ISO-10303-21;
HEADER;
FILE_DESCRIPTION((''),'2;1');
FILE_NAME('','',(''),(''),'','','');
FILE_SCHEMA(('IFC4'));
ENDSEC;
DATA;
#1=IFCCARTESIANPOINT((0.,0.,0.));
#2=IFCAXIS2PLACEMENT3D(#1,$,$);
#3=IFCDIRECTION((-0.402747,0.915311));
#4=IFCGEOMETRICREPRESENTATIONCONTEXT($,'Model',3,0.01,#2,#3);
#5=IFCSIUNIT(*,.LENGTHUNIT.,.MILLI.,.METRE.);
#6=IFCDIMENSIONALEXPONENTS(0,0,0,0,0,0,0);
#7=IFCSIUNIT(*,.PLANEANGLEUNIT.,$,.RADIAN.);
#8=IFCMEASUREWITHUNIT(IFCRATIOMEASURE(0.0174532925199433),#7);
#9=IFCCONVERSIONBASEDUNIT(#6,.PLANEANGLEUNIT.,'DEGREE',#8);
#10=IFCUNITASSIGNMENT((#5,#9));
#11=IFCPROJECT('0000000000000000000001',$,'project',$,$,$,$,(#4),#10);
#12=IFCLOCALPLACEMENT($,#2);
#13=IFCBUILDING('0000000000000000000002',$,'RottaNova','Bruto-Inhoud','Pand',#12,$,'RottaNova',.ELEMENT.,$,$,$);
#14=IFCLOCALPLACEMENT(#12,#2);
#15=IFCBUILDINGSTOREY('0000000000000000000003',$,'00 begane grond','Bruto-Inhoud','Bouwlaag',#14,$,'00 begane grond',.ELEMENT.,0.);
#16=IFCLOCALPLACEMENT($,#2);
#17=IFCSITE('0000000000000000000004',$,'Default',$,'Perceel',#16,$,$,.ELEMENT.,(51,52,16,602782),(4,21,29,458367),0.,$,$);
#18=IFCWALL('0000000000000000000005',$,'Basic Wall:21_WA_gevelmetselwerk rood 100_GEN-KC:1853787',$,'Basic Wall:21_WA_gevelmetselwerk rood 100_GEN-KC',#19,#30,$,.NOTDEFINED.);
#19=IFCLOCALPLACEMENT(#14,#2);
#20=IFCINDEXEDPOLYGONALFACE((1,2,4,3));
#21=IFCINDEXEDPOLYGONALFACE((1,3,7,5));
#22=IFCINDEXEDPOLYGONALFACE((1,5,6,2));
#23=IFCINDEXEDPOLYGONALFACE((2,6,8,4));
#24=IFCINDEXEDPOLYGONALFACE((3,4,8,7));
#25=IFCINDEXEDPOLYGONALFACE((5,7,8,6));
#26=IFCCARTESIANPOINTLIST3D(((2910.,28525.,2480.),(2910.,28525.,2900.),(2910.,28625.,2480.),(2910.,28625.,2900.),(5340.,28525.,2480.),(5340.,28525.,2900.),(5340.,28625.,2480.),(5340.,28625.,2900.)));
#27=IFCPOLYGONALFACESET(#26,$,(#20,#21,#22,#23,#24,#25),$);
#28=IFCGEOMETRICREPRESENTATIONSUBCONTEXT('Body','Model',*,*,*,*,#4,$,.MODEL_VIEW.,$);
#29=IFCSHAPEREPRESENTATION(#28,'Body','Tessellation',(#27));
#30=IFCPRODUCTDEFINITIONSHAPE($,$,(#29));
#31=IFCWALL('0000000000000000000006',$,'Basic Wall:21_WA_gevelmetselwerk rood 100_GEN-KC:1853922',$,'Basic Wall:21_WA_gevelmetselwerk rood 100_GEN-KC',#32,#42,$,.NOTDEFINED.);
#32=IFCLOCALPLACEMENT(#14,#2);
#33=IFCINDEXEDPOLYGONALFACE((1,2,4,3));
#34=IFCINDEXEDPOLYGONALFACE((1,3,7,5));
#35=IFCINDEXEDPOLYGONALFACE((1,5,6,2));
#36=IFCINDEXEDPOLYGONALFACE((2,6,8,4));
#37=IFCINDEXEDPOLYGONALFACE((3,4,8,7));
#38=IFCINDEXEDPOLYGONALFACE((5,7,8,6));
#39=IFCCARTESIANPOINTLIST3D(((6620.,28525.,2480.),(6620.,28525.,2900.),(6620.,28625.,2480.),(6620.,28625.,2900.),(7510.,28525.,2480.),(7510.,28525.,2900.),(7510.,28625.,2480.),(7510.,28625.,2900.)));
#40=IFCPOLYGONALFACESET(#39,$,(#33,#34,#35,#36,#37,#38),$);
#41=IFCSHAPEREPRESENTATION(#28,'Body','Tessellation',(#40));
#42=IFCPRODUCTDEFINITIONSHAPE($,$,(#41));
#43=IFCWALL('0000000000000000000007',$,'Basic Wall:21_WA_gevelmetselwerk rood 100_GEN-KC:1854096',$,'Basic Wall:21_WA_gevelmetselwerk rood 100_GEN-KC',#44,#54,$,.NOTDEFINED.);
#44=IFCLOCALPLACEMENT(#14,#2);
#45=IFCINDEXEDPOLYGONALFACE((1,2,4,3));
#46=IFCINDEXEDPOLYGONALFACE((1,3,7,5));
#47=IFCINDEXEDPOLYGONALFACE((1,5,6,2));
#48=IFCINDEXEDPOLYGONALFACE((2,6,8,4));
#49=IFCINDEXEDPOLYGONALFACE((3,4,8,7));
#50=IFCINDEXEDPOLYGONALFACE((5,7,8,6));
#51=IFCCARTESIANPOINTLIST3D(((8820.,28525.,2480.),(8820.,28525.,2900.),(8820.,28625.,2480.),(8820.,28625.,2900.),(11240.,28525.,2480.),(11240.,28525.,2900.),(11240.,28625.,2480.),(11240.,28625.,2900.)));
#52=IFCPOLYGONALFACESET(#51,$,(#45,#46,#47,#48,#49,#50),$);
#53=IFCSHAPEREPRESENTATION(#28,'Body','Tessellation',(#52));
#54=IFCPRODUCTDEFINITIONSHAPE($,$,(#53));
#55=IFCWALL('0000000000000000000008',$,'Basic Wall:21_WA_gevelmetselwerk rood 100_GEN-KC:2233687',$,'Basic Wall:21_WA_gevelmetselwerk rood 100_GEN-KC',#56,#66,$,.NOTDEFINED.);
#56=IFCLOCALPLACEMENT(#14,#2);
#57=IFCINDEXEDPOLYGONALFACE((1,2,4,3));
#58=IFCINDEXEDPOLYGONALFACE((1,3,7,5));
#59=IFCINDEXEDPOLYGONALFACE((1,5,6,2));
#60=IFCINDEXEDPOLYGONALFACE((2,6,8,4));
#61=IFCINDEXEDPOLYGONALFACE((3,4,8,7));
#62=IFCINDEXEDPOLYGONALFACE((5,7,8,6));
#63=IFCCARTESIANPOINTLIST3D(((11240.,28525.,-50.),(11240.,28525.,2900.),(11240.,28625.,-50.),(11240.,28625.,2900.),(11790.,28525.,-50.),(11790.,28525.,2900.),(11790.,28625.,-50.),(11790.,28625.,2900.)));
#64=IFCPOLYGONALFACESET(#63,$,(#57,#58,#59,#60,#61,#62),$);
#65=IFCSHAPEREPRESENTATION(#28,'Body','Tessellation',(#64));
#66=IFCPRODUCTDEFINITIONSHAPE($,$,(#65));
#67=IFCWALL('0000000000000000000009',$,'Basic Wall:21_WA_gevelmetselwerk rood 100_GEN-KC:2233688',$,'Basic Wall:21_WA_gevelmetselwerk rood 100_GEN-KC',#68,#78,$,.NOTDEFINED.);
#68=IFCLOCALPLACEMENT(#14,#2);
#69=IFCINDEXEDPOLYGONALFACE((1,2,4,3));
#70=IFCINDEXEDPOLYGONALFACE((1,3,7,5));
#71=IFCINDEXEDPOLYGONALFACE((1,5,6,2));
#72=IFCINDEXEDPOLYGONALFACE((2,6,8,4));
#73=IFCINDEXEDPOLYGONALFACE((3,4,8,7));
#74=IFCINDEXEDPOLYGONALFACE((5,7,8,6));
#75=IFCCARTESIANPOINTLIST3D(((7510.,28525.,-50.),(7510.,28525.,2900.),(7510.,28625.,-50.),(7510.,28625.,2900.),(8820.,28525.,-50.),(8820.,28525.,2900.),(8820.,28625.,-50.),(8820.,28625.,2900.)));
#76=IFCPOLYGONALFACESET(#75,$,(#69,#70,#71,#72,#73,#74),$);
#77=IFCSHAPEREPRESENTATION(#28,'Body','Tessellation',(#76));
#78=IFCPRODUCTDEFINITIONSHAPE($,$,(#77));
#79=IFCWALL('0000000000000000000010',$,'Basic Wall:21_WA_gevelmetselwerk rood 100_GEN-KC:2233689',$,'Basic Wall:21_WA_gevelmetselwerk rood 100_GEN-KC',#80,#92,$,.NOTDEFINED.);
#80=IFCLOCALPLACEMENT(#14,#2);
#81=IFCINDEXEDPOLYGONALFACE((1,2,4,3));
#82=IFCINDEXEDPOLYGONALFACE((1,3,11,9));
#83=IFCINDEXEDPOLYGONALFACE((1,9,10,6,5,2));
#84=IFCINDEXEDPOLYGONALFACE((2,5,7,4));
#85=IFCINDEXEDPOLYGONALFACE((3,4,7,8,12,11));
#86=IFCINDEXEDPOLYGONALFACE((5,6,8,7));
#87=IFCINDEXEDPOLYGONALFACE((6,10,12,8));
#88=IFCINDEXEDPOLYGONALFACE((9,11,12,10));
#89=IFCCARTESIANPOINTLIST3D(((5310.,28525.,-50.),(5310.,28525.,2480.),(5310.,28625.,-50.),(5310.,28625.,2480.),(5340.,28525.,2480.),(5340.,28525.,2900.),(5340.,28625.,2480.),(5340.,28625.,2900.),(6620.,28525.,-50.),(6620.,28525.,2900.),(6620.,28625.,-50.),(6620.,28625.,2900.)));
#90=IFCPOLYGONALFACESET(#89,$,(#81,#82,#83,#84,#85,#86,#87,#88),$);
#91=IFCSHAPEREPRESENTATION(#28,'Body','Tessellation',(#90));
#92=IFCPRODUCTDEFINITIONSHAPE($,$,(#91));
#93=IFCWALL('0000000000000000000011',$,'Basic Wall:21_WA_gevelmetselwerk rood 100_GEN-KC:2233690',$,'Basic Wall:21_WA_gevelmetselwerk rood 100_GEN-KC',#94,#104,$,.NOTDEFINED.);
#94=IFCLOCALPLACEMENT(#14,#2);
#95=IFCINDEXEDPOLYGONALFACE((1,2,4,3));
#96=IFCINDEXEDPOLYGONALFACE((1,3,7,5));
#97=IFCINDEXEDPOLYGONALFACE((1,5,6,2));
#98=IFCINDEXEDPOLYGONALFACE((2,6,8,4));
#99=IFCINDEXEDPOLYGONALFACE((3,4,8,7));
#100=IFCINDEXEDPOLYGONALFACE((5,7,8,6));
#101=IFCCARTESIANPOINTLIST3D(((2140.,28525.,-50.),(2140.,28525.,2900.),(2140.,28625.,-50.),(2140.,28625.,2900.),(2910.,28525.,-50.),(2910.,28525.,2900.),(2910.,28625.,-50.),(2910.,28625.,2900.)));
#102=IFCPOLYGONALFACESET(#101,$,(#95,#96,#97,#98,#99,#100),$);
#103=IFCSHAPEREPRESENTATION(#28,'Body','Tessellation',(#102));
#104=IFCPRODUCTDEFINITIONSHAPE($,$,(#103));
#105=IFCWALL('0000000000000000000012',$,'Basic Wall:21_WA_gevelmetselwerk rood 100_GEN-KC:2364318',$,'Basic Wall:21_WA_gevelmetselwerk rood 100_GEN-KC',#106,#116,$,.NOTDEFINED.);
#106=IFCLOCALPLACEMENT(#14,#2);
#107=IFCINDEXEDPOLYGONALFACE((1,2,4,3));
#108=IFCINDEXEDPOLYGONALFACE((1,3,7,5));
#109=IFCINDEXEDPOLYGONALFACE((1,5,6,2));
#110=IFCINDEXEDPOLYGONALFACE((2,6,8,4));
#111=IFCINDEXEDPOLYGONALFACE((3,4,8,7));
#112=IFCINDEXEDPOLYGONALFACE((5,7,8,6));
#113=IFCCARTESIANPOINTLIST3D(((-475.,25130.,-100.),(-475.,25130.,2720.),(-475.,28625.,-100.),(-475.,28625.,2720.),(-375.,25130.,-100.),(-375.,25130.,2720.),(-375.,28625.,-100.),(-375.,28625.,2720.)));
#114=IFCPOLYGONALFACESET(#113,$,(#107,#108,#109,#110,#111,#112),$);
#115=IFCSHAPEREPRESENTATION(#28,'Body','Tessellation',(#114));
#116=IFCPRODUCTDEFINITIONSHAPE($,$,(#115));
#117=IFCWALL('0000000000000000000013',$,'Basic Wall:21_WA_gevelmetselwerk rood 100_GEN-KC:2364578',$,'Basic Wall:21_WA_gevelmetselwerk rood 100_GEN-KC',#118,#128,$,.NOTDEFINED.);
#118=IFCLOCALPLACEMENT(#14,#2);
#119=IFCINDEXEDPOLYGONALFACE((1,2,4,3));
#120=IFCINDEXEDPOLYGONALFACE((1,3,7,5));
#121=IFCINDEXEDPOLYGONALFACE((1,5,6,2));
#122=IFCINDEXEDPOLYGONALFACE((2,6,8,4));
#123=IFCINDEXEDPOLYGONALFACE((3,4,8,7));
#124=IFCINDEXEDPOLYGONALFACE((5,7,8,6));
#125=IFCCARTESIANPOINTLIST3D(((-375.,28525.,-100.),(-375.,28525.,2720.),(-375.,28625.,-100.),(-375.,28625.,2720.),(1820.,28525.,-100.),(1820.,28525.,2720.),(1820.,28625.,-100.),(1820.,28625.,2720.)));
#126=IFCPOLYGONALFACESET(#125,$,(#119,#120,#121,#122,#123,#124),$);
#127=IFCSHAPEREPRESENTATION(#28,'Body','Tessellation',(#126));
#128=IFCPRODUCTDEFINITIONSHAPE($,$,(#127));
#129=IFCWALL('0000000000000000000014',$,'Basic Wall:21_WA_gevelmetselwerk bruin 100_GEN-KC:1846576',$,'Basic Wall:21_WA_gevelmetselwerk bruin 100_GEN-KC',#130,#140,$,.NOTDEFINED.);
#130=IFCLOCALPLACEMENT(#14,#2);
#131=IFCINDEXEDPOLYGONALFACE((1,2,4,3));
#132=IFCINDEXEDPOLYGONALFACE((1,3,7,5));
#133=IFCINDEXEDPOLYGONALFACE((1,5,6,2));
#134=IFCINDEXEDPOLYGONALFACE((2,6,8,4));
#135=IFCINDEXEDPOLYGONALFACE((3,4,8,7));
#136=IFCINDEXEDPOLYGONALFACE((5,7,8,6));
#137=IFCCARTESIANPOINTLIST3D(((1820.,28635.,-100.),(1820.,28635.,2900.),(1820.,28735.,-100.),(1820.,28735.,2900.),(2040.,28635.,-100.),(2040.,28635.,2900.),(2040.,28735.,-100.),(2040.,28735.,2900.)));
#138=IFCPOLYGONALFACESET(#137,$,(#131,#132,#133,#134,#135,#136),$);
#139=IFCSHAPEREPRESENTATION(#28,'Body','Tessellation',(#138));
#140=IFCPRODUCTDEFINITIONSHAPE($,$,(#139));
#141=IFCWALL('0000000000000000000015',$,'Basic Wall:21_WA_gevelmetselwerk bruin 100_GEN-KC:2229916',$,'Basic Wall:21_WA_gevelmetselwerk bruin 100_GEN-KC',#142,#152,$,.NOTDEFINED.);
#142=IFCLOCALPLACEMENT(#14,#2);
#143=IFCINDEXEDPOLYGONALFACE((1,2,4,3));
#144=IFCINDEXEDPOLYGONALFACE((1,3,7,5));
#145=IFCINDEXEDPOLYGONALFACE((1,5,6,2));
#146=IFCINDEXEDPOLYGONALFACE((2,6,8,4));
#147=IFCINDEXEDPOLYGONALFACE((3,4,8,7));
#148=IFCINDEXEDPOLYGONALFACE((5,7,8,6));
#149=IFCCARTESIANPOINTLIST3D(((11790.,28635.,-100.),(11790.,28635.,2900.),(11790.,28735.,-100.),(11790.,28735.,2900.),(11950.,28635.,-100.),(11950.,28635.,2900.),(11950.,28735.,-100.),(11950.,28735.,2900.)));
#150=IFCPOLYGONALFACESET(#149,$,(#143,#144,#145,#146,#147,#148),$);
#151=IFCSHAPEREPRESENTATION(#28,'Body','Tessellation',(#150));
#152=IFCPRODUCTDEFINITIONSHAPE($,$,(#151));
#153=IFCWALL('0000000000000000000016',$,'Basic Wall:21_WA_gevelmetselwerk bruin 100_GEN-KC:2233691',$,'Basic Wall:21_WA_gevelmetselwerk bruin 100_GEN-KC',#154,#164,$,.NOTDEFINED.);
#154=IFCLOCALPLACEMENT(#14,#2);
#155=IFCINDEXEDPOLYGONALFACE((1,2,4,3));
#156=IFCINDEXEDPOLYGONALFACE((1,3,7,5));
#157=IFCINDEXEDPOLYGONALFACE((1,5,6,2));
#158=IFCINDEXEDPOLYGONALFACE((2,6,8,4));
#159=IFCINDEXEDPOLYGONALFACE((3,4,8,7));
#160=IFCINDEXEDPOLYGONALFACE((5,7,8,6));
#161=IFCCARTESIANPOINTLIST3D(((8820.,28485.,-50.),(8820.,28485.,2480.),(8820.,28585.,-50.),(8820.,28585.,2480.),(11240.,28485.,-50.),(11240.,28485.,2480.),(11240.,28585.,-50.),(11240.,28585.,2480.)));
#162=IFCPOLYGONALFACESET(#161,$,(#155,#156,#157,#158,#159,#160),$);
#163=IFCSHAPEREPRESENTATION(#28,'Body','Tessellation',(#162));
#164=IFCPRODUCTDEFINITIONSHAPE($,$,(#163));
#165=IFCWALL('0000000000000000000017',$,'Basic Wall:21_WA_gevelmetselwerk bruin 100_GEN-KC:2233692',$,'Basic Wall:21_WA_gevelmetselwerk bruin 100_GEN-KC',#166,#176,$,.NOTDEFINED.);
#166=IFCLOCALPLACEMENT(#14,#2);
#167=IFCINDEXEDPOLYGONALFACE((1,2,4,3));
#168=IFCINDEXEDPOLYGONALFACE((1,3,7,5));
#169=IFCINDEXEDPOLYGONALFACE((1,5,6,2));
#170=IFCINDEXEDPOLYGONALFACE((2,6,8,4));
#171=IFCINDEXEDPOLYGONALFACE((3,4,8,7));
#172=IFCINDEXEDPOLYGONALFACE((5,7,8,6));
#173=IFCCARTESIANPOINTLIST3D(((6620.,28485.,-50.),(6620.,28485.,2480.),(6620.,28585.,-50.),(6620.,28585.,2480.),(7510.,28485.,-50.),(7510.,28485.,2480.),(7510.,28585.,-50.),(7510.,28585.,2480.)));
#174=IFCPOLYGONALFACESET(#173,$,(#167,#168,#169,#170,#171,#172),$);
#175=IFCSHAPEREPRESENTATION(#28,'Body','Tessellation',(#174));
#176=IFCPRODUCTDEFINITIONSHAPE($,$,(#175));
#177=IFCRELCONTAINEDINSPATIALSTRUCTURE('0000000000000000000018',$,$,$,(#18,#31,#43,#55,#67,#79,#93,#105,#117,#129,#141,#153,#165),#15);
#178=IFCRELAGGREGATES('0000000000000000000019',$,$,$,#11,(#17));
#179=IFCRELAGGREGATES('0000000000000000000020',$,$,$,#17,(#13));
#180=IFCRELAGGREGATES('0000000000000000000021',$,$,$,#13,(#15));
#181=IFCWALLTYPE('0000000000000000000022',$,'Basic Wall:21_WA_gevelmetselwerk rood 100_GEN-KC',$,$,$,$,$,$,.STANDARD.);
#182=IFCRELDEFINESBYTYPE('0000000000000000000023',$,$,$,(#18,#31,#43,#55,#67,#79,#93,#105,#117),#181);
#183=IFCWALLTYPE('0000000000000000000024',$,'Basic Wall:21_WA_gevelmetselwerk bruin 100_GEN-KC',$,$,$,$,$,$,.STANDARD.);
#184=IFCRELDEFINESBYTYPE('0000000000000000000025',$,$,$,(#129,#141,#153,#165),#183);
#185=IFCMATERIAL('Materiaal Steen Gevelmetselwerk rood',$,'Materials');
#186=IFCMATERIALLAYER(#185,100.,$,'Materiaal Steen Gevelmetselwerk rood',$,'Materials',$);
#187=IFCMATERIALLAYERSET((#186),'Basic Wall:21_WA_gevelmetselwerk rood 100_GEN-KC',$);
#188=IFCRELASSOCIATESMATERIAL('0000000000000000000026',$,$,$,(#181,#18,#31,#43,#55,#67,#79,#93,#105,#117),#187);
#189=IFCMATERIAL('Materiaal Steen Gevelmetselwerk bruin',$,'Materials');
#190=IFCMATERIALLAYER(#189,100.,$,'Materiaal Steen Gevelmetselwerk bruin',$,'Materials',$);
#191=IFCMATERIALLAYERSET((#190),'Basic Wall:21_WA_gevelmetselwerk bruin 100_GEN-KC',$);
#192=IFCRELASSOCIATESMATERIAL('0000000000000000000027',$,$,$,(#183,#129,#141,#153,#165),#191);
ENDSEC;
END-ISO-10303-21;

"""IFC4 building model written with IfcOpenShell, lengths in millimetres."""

from ifc_helpers import new_model, entity, si_unit, converted_unit, direction, frame, frame_2d, origin, place, context, subcontext, project, spatial, polyline, rectangle, extrude, clip, bounded_halfspace, material, layer, layer_set, type_object, element, save


model = new_model("IFC4")

# Units and contexts
model_context = context("Model", 3, precision=0.01, world=origin(), true_north=direction((-0.402747, 0.915311)))
body_context = subcontext(model_context, "Body", "Model", "MODEL_VIEW")
ifc_project = project(units=[si_unit("LENGTHUNIT", "METRE", prefix="MILLI"), converted_unit("PLANEANGLEUNIT", "DEGREE", entity("IfcRatioMeasure", 0.0174532925199433), si_unit("PLANEANGLEUNIT", "RADIAN"), dimensions=[0, 0, 0, 0, 0, 0, 0])], contexts=[model_context])

# Site, building, storey
site_placement = place(None, origin())
site = spatial("IfcSite", under=ifc_project, at=site_placement, Name="Default", ObjectType="Perceel", CompositionType="ELEMENT", RefLatitude=(51, 52, 16, 602782), RefLongitude=(4, 21, 29, 458367), RefElevation=0.0)
building_placement = place(None, origin())
building = spatial("IfcBuilding", under=site, at=building_placement, Name="RottaNova", Description="Bruto-Inhoud", ObjectType="Pand", LongName="RottaNova", CompositionType="ELEMENT")
storey_placement = place(building_placement, origin())
storey = spatial("IfcBuildingStorey", under=building, at=storey_placement, Name="00 begane grond", Description="Bruto-Inhoud", ObjectType="Bouwlaag", LongName="00 begane grond", CompositionType="ELEMENT", Elevation=0.0)

# Walls
ifc_material_1 = material(Name="Materiaal Steen Gevelmetselwerk rood", Category="Materials")
ifc_layer_1 = layer(ifc_material_1, 100.0, Name="Materiaal Steen Gevelmetselwerk rood", Category="Materials")
ifc_layer_set_1 = layer_set([ifc_layer_1], Name="Basic Wall:21_WA_gevelmetselwerk rood 100_GEN-KC")
wall_type_1 = type_object("IfcWallType", Name="Basic Wall:21_WA_gevelmetselwerk rood 100_GEN-KC", PredefinedType="STANDARD", material=ifc_layer_set_1)
wall_1_placement = place(storey_placement, frame((2910.0, 28575.0, 2480.0)))
element("IfcWall", 1, at=wall_1_placement, inside=storey, type_object=wall_type_1, material=ifc_layer_set_1, Name="Basic Wall:21_WA_gevelmetselwerk rood 100_GEN-KC:1853787", ObjectType="Basic Wall:21_WA_gevelmetselwerk rood 100_GEN-KC", PredefinedType="NOTDEFINED", context=body_context, shape_type="SweptSolid", body=[
    extrude(rectangle(XDim=2430.0, YDim=100.0, at=frame_2d((1215.0, 0.0), x_axis=(-1.0, 0.0))), origin(), (0.0, 0.0, 1.0), 420.0),
])
wall_2_placement = place(storey_placement, frame((6620.0, 28575.0, 2480.0)))
element("IfcWall", 2, at=wall_2_placement, inside=storey, type_object=wall_type_1, material=ifc_layer_set_1, Name="Basic Wall:21_WA_gevelmetselwerk rood 100_GEN-KC:1853922", ObjectType="Basic Wall:21_WA_gevelmetselwerk rood 100_GEN-KC", PredefinedType="NOTDEFINED", context=body_context, shape_type="Clipping", body=[
    clip(extrude(rectangle(XDim=890.0, YDim=100.0, at=frame_2d((445.0, 0.0), x_axis=(-1.0, 0.0))), origin(), (0.0, 0.0, 1.0), 420.0), bounded_halfspace(frame((890.0, -50.0, 420.0), z_axis=(-1.0, 0.0, 0.0), x_axis=(0.0, 1.0, 0.0)), True, frame((890.0, -50.0, 420.0), z_axis=(-1.0, 0.0, 0.0), x_axis=(0.0, 1.0, 0.0)), polyline([(0.0, 0.0), (30480.0, 0.0), (30480.0, 128016.0), (0.0, 128016.0), (0.0, 0.0)]))),
])
wall_3_placement = place(storey_placement, frame((8820.0, 28575.0, 2480.0)))
element("IfcWall", 3, at=wall_3_placement, inside=storey, type_object=wall_type_1, material=ifc_layer_set_1, Name="Basic Wall:21_WA_gevelmetselwerk rood 100_GEN-KC:1854096", ObjectType="Basic Wall:21_WA_gevelmetselwerk rood 100_GEN-KC", PredefinedType="NOTDEFINED", context=body_context, shape_type="SweptSolid", body=[
    extrude(rectangle(XDim=2420.0, YDim=100.0, at=frame_2d((1210.0, 0.0), x_axis=(-1.0, 0.0))), origin(), (0.0, 0.0, 1.0), 420.0),
])
wall_4_placement = place(storey_placement, frame((11240.0, 28575.0, -50.0)))
element("IfcWall", 4, at=wall_4_placement, inside=storey, type_object=wall_type_1, material=ifc_layer_set_1, Name="Basic Wall:21_WA_gevelmetselwerk rood 100_GEN-KC:2233687", ObjectType="Basic Wall:21_WA_gevelmetselwerk rood 100_GEN-KC", PredefinedType="NOTDEFINED", context=body_context, shape_type="SweptSolid", body=[
    extrude(rectangle(XDim=550.0, YDim=100.0, at=frame_2d((275.0, 0.0), x_axis=(-1.0, 0.0))), origin(), (0.0, 0.0, 1.0), 2950.0),
])
wall_5_placement = place(storey_placement, frame((7510.0, 28575.0, -50.0)))
element("IfcWall", 5, at=wall_5_placement, inside=storey, type_object=wall_type_1, material=ifc_layer_set_1, Name="Basic Wall:21_WA_gevelmetselwerk rood 100_GEN-KC:2233688", ObjectType="Basic Wall:21_WA_gevelmetselwerk rood 100_GEN-KC", PredefinedType="NOTDEFINED", context=body_context, shape_type="SweptSolid", body=[
    extrude(rectangle(XDim=1310.0, YDim=100.0, at=frame_2d((655.0, 0.0), x_axis=(-1.0, 0.0))), origin(), (0.0, 0.0, 1.0), 2950.0),
])
wall_6_placement = place(storey_placement, frame((5310.0, 28575.0, -50.0)))
element("IfcWall", 6, at=wall_6_placement, inside=storey, type_object=wall_type_1, material=ifc_layer_set_1, Name="Basic Wall:21_WA_gevelmetselwerk rood 100_GEN-KC:2233689", ObjectType="Basic Wall:21_WA_gevelmetselwerk rood 100_GEN-KC", PredefinedType="NOTDEFINED", context=body_context, shape_type="Clipping", body=[
    clip(clip(extrude(rectangle(XDim=1310.0, YDim=100.0, at=frame_2d((655.0, 0.0), x_axis=(-1.0, 0.0))), origin(), (0.0, 0.0, 1.0), 2950.0), bounded_halfspace(frame((30.0, -50.0, 2530.0), z_axis=(0.0, 0.0, -1.0), x_axis=(0.0, 1.0, 0.0)), True, frame((30.0, -50.0, 2530.0), z_axis=(0.0, 0.0, -1.0), x_axis=(0.0, 1.0, 0.0)), polyline([(0.0, 0.0), (0.0, -30.0), (100.0, -30.0), (100.0, 0.0), (0.0, 0.0)]))), bounded_halfspace(frame((30.0, 50.0, 2530.0), z_axis=(1.0, 0.0, 0.0), x_axis=(0.0, 1.0, 0.0)), True, frame((30.0, 50.0, 2530.0), z_axis=(1.0, 0.0, 0.0), x_axis=(0.0, 1.0, 0.0)), polyline([(0.0, 0.0), (0.0, 128016.0), (-30480.0, 128016.0), (-30480.0, 0.0), (0.0, 0.0)]))),
])
wall_7_placement = place(storey_placement, frame((2140.0, 28575.0, -50.0)))
element("IfcWall", 7, at=wall_7_placement, inside=storey, type_object=wall_type_1, material=ifc_layer_set_1, Name="Basic Wall:21_WA_gevelmetselwerk rood 100_GEN-KC:2233690", ObjectType="Basic Wall:21_WA_gevelmetselwerk rood 100_GEN-KC", PredefinedType="NOTDEFINED", context=body_context, shape_type="SweptSolid", body=[
    extrude(rectangle(XDim=770.0, YDim=100.0, at=frame_2d((385.0, 0.0), x_axis=(-1.0, 0.0))), origin(), (0.0, 0.0, 1.0), 2950.0),
])
wall_8_placement = place(storey_placement, frame((-425.0, 25130.0, -100.0), z_axis=(0.0, 0.0, 1.0), x_axis=(0.0, 1.0, 0.0)))
element("IfcWall", 8, at=wall_8_placement, inside=storey, type_object=wall_type_1, material=ifc_layer_set_1, Name="Basic Wall:21_WA_gevelmetselwerk rood 100_GEN-KC:2364318", ObjectType="Basic Wall:21_WA_gevelmetselwerk rood 100_GEN-KC", PredefinedType="NOTDEFINED", context=body_context, shape_type="SweptSolid", body=[
    extrude(rectangle(XDim=3495.0, YDim=100.0, at=frame_2d((1747.5, 0.0), x_axis=(-1.0, 0.0))), origin(), (0.0, 0.0, 1.0), 2820.0),
])
wall_9_placement = place(storey_placement, frame((1820.0, 28575.0, -100.0), z_axis=(0.0, 0.0, 1.0), x_axis=(-1.0, 0.0, 0.0)))
element("IfcWall", 9, at=wall_9_placement, inside=storey, type_object=wall_type_1, material=ifc_layer_set_1, Name="Basic Wall:21_WA_gevelmetselwerk rood 100_GEN-KC:2364578", ObjectType="Basic Wall:21_WA_gevelmetselwerk rood 100_GEN-KC", PredefinedType="NOTDEFINED", context=body_context, shape_type="SweptSolid", body=[
    extrude(rectangle(XDim=2195.0, YDim=100.0, at=frame_2d((1097.5, 0.0), x_axis=(-1.0, 0.0))), origin(), (0.0, 0.0, 1.0), 2820.0),
])
ifc_material_2 = material(Name="Materiaal Steen Gevelmetselwerk bruin", Category="Materials")
ifc_layer_2 = layer(ifc_material_2, 100.0, Name="Materiaal Steen Gevelmetselwerk bruin", Category="Materials")
ifc_layer_set_2 = layer_set([ifc_layer_2], Name="Basic Wall:21_WA_gevelmetselwerk bruin 100_GEN-KC")
wall_type_2 = type_object("IfcWallType", Name="Basic Wall:21_WA_gevelmetselwerk bruin 100_GEN-KC", PredefinedType="STANDARD", material=ifc_layer_set_2)
wall_10_placement = place(storey_placement, frame((1820.0, 28685.0, -100.0)))
element("IfcWall", 10, at=wall_10_placement, inside=storey, type_object=wall_type_2, material=ifc_layer_set_2, Name="Basic Wall:21_WA_gevelmetselwerk bruin 100_GEN-KC:1846576", ObjectType="Basic Wall:21_WA_gevelmetselwerk bruin 100_GEN-KC", PredefinedType="NOTDEFINED", context=body_context, shape_type="SweptSolid", body=[
    extrude(rectangle(XDim=220.0, YDim=100.0, at=frame_2d((110.0, 0.0), x_axis=(-1.0, 0.0))), origin(), (0.0, 0.0, 1.0), 3000.0),
])
wall_11_placement = place(storey_placement, frame((11790.0, 28685.0, -100.0)))
element("IfcWall", 11, at=wall_11_placement, inside=storey, type_object=wall_type_2, material=ifc_layer_set_2, Name="Basic Wall:21_WA_gevelmetselwerk bruin 100_GEN-KC:2229916", ObjectType="Basic Wall:21_WA_gevelmetselwerk bruin 100_GEN-KC", PredefinedType="NOTDEFINED", context=body_context, shape_type="SweptSolid", body=[
    extrude(rectangle(XDim=160.0, YDim=100.0, at=frame_2d((80.0, 0.0), x_axis=(-1.0, 0.0))), origin(), (0.0, 0.0, 1.0), 3000.0),
])
wall_12_placement = place(storey_placement, frame((11240.0, 28535.0, -50.0), z_axis=(0.0, 0.0, 1.0), x_axis=(-1.0, 0.0, 0.0)))
element("IfcWall", 12, at=wall_12_placement, inside=storey, type_object=wall_type_2, material=ifc_layer_set_2, Name="Basic Wall:21_WA_gevelmetselwerk bruin 100_GEN-KC:2233691", ObjectType="Basic Wall:21_WA_gevelmetselwerk bruin 100_GEN-KC", PredefinedType="NOTDEFINED", context=body_context, shape_type="SweptSolid", body=[
    extrude(rectangle(XDim=2420.0, YDim=100.0, at=frame_2d((1210.0, 0.0), x_axis=(-1.0, 0.0))), origin(), (0.0, 0.0, 1.0), 2530.0),
])
wall_13_placement = place(storey_placement, frame((7510.0, 28535.0, -50.0), z_axis=(0.0, 0.0, 1.0), x_axis=(-1.0, 0.0, 0.0)))
element("IfcWall", 13, at=wall_13_placement, inside=storey, type_object=wall_type_2, material=ifc_layer_set_2, Name="Basic Wall:21_WA_gevelmetselwerk bruin 100_GEN-KC:2233692", ObjectType="Basic Wall:21_WA_gevelmetselwerk bruin 100_GEN-KC", PredefinedType="NOTDEFINED", context=body_context, shape_type="SweptSolid", body=[
    extrude(rectangle(XDim=890.0, YDim=100.0, at=frame_2d((445.0, 0.0), x_axis=(-1.0, 0.0))), origin(), (0.0, 0.0, 1.0), 2530.0),
])

save(model, "model.ifc")
